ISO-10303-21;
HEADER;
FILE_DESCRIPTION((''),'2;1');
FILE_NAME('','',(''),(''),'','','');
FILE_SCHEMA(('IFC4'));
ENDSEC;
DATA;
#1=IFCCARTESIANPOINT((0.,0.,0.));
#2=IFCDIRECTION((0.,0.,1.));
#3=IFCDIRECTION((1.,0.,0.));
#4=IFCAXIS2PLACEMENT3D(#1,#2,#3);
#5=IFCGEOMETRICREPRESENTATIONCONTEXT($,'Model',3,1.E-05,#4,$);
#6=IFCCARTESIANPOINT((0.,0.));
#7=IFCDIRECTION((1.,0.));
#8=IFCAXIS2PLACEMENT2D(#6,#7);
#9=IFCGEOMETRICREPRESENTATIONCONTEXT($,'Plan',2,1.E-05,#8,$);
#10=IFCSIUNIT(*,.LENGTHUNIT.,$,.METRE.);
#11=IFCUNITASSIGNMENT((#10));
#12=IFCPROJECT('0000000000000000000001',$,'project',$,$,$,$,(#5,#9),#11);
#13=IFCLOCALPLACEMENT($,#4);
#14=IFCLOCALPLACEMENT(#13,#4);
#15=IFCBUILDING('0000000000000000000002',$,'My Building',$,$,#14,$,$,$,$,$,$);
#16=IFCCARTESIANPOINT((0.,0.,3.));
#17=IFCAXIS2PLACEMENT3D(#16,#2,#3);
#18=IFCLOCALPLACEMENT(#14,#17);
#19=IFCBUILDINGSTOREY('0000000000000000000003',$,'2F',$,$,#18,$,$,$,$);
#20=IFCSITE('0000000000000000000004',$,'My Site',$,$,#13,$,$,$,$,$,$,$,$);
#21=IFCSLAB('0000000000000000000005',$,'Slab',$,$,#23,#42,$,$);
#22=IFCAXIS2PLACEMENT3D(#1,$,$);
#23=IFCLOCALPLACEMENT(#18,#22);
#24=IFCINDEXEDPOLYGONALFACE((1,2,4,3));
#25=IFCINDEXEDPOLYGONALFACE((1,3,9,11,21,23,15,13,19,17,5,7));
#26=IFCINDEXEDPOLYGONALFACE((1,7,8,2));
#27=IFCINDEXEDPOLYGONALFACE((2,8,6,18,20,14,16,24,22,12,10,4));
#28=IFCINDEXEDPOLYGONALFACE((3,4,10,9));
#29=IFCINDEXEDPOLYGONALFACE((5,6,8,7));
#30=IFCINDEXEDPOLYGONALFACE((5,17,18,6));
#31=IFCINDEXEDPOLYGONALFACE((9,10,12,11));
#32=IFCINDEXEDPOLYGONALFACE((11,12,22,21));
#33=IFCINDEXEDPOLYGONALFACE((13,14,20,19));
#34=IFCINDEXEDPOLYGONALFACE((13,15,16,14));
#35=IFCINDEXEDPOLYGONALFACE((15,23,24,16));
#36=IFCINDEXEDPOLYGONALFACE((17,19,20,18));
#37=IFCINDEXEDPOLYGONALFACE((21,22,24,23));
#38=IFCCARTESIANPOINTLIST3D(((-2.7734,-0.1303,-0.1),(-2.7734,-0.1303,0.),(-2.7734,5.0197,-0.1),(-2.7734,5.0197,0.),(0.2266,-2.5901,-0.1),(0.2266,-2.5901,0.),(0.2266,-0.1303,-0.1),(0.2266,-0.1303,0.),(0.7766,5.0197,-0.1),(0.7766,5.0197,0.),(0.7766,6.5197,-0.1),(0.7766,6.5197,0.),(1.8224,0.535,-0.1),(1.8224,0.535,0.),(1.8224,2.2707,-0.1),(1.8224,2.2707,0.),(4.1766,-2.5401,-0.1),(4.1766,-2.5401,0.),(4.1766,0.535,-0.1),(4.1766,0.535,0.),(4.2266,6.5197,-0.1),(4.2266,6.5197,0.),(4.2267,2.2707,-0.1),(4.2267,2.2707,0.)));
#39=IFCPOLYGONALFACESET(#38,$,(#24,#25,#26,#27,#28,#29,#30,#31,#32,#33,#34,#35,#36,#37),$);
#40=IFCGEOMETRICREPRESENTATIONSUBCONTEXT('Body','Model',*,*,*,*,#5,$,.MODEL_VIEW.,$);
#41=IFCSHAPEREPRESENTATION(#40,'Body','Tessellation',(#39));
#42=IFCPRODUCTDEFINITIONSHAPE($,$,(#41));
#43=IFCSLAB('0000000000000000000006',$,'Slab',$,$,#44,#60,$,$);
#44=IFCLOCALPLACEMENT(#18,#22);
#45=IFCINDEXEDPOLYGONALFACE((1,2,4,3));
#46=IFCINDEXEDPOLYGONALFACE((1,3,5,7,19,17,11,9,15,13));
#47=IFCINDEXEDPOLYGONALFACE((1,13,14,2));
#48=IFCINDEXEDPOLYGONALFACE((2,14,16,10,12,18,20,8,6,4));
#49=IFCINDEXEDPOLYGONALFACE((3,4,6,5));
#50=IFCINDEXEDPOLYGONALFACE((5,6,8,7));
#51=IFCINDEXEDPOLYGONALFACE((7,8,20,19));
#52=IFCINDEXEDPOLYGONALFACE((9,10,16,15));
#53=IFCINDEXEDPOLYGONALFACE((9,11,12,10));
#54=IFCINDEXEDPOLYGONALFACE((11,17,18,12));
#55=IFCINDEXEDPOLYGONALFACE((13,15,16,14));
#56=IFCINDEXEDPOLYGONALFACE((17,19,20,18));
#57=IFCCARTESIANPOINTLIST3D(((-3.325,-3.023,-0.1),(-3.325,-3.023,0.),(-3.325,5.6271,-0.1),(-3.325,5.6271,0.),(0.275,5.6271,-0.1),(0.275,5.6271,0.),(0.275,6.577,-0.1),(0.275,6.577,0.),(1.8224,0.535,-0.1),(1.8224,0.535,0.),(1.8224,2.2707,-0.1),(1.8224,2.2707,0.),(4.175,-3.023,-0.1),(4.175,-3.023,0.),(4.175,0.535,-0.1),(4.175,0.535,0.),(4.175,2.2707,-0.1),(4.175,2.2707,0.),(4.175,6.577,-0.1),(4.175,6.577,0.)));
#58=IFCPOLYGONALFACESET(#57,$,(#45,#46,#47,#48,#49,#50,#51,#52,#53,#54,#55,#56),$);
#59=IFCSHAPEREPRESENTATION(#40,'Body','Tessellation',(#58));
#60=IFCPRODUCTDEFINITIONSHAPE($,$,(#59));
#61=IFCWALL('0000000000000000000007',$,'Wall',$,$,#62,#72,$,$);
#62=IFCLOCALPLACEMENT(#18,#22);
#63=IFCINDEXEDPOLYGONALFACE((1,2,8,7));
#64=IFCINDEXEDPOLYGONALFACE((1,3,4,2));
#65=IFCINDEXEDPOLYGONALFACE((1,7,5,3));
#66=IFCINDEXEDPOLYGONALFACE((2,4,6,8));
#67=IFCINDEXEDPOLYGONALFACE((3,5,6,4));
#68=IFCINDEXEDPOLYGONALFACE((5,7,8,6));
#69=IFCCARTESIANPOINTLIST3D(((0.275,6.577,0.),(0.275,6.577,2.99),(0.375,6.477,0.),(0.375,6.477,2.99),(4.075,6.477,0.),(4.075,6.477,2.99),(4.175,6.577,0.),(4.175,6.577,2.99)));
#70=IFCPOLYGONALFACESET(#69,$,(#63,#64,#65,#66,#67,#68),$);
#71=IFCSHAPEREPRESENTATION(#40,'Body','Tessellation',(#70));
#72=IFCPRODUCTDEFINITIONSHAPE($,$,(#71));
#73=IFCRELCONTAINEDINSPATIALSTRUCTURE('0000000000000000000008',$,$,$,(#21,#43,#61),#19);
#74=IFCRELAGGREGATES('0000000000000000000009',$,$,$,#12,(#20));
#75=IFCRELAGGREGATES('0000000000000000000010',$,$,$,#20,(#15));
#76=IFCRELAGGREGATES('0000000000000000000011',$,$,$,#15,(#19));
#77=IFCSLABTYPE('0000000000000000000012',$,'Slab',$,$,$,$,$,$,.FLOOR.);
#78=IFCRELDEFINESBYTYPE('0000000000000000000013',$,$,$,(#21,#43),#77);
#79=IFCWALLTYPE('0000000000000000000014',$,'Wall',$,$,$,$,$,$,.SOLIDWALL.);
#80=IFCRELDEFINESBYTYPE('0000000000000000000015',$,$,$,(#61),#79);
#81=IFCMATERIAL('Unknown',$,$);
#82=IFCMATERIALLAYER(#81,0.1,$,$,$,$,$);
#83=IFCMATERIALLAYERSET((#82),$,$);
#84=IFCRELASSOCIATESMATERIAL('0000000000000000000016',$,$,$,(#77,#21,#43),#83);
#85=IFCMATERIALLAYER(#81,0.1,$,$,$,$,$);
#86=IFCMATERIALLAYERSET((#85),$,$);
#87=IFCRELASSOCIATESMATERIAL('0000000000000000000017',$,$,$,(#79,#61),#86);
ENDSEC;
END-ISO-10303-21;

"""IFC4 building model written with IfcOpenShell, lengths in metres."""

from ifc_helpers import new_model, si_unit, frame, origin_with_axes, origin_2d_with_axis, place, context, subcontext, project, spatial, line, indexed_curve, outline, extrude, material, layer, layer_set, layer_usage, type_object, element, save


model = new_model("IFC4")

# Units and contexts
model_context = context("Model", 3, precision=1e-05, world=origin_with_axes())
plan_context = context("Plan", 2, precision=1e-05, world=origin_2d_with_axis())
body_context_1 = subcontext(model_context, "Body", "Model", "MODEL_VIEW")
ifc_project = project(units=[si_unit("LENGTHUNIT", "METRE")], contexts=[model_context, plan_context])

# Site, building, storey
site_placement = place(None, origin_with_axes())
site = spatial("IfcSite", under=ifc_project, at=site_placement, Name="My Site")
building_placement = place(site_placement, origin_with_axes())
building = spatial("IfcBuilding", under=site, at=building_placement, Name="My Building")
storey_placement = place(building_placement, frame((0.0, 0.0, 3.0), z_axis=(0.0, 0.0, 1.0), x_axis=(1.0, 0.0, 0.0)))
storey = spatial("IfcBuildingStorey", under=building, at=storey_placement, Name="2F")

# Slabs
ifc_material = material(Name="Unknown")
ifc_layer_1 = layer(ifc_material, 0.1)
ifc_layer_set_1 = layer_set([ifc_layer_1])
ifc_layer_usage_1 = layer_usage(ifc_layer_set_1, "AXIS3", "POSITIVE", -0.1)
slab_type = type_object("IfcSlabType", Name="Slab", PredefinedType="FLOOR", material=ifc_layer_set_1)
slab_1_placement = place(storey_placement, frame((4.2266, 6.5197, 0.0), z_axis=(0.0, 0.0, 1.0), x_axis=(1.0, 0.0, 0.0)))
element("IfcSlab", 1, at=slab_1_placement, inside=storey, type_object=slab_type, material=ifc_layer_usage_1, Name="Slab", context=body_context_1, shape_type="SweptSolid", body=[
    extrude(outline(indexed_curve([(0.0, 0.0), (-3.45, 0.0), (-3.45, -1.5), (-7.0, -1.5), (-7.0, -6.65), (-4.0, -6.65), (-4.0, -9.1098), (-0.05, -9.0598), (-0.05, -5.9848), (-2.4042, -5.9848), (-2.4042, -4.249), (0.0001, -4.249), (0.0, 0.0)])), frame((0.0, 0.0, -0.1), z_axis=(0.0, 0.0, 1.0), x_axis=(1.0, 0.0, 0.0)), (0.0, 0.0, 1.0), 0.1),
])
ifc_layer_usage_2 = layer_usage(ifc_layer_set_1, "AXIS3", "POSITIVE", -0.1)
slab_2_placement = place(storey_placement, frame((4.175, -3.023, 0.0), z_axis=(0.0, 0.0, 1.0), x_axis=(1.0, 0.0, 0.0)))
element("IfcSlab", 2, at=slab_2_placement, inside=storey, type_object=slab_type, material=ifc_layer_usage_2, Name="Slab", context=body_context_1, shape_type="SweptSolid", body=[
    extrude(outline(indexed_curve([(0.0, 0.0), (0.0, 3.5579), (-2.3526, 3.5579), (-2.3526, 5.2937), (0.0, 5.2937), (0.0, 9.6), (-3.9, 9.6), (-3.9, 8.65), (-7.5, 8.65), (-7.5, 0.0), (0.0, 0.0)])), frame((0.0, 0.0, -0.1), z_axis=(0.0, 0.0, 1.0), x_axis=(1.0, 0.0, 0.0)), (0.0, 0.0, 1.0), 0.1),
])

# Wall
ifc_layer_2 = layer(ifc_material, 0.1)
ifc_layer_set_2 = layer_set([ifc_layer_2])
ifc_layer_usage_3 = layer_usage(ifc_layer_set_2, "AXIS2", "POSITIVE", 0.0)
wall_type = type_object("IfcWallType", Name="Wall", PredefinedType="SOLIDWALL", material=ifc_layer_set_2)
wall_1_placement = place(storey_placement, frame((4.175, 6.577, 0.0), z_axis=(0.0, 0.0, 1.0), x_axis=(-1.0, 0.0, 0.0)))
element("IfcWall", 3, at=wall_1_placement, inside=storey, type_object=wall_type, material=ifc_layer_usage_3, Name="Wall", context=body_context_1, shape_type="SweptSolid", body=[
    extrude(outline(indexed_curve([(0.0, 0.0), (0.1, 0.1), (3.8, 0.1), (3.9, 0.0)], segments=[line(1, 2, 3, 4, 1)])), origin_with_axes(), (0.0, 0.0, 1.0), 2.99),
])

save(model, "model.ifc")
